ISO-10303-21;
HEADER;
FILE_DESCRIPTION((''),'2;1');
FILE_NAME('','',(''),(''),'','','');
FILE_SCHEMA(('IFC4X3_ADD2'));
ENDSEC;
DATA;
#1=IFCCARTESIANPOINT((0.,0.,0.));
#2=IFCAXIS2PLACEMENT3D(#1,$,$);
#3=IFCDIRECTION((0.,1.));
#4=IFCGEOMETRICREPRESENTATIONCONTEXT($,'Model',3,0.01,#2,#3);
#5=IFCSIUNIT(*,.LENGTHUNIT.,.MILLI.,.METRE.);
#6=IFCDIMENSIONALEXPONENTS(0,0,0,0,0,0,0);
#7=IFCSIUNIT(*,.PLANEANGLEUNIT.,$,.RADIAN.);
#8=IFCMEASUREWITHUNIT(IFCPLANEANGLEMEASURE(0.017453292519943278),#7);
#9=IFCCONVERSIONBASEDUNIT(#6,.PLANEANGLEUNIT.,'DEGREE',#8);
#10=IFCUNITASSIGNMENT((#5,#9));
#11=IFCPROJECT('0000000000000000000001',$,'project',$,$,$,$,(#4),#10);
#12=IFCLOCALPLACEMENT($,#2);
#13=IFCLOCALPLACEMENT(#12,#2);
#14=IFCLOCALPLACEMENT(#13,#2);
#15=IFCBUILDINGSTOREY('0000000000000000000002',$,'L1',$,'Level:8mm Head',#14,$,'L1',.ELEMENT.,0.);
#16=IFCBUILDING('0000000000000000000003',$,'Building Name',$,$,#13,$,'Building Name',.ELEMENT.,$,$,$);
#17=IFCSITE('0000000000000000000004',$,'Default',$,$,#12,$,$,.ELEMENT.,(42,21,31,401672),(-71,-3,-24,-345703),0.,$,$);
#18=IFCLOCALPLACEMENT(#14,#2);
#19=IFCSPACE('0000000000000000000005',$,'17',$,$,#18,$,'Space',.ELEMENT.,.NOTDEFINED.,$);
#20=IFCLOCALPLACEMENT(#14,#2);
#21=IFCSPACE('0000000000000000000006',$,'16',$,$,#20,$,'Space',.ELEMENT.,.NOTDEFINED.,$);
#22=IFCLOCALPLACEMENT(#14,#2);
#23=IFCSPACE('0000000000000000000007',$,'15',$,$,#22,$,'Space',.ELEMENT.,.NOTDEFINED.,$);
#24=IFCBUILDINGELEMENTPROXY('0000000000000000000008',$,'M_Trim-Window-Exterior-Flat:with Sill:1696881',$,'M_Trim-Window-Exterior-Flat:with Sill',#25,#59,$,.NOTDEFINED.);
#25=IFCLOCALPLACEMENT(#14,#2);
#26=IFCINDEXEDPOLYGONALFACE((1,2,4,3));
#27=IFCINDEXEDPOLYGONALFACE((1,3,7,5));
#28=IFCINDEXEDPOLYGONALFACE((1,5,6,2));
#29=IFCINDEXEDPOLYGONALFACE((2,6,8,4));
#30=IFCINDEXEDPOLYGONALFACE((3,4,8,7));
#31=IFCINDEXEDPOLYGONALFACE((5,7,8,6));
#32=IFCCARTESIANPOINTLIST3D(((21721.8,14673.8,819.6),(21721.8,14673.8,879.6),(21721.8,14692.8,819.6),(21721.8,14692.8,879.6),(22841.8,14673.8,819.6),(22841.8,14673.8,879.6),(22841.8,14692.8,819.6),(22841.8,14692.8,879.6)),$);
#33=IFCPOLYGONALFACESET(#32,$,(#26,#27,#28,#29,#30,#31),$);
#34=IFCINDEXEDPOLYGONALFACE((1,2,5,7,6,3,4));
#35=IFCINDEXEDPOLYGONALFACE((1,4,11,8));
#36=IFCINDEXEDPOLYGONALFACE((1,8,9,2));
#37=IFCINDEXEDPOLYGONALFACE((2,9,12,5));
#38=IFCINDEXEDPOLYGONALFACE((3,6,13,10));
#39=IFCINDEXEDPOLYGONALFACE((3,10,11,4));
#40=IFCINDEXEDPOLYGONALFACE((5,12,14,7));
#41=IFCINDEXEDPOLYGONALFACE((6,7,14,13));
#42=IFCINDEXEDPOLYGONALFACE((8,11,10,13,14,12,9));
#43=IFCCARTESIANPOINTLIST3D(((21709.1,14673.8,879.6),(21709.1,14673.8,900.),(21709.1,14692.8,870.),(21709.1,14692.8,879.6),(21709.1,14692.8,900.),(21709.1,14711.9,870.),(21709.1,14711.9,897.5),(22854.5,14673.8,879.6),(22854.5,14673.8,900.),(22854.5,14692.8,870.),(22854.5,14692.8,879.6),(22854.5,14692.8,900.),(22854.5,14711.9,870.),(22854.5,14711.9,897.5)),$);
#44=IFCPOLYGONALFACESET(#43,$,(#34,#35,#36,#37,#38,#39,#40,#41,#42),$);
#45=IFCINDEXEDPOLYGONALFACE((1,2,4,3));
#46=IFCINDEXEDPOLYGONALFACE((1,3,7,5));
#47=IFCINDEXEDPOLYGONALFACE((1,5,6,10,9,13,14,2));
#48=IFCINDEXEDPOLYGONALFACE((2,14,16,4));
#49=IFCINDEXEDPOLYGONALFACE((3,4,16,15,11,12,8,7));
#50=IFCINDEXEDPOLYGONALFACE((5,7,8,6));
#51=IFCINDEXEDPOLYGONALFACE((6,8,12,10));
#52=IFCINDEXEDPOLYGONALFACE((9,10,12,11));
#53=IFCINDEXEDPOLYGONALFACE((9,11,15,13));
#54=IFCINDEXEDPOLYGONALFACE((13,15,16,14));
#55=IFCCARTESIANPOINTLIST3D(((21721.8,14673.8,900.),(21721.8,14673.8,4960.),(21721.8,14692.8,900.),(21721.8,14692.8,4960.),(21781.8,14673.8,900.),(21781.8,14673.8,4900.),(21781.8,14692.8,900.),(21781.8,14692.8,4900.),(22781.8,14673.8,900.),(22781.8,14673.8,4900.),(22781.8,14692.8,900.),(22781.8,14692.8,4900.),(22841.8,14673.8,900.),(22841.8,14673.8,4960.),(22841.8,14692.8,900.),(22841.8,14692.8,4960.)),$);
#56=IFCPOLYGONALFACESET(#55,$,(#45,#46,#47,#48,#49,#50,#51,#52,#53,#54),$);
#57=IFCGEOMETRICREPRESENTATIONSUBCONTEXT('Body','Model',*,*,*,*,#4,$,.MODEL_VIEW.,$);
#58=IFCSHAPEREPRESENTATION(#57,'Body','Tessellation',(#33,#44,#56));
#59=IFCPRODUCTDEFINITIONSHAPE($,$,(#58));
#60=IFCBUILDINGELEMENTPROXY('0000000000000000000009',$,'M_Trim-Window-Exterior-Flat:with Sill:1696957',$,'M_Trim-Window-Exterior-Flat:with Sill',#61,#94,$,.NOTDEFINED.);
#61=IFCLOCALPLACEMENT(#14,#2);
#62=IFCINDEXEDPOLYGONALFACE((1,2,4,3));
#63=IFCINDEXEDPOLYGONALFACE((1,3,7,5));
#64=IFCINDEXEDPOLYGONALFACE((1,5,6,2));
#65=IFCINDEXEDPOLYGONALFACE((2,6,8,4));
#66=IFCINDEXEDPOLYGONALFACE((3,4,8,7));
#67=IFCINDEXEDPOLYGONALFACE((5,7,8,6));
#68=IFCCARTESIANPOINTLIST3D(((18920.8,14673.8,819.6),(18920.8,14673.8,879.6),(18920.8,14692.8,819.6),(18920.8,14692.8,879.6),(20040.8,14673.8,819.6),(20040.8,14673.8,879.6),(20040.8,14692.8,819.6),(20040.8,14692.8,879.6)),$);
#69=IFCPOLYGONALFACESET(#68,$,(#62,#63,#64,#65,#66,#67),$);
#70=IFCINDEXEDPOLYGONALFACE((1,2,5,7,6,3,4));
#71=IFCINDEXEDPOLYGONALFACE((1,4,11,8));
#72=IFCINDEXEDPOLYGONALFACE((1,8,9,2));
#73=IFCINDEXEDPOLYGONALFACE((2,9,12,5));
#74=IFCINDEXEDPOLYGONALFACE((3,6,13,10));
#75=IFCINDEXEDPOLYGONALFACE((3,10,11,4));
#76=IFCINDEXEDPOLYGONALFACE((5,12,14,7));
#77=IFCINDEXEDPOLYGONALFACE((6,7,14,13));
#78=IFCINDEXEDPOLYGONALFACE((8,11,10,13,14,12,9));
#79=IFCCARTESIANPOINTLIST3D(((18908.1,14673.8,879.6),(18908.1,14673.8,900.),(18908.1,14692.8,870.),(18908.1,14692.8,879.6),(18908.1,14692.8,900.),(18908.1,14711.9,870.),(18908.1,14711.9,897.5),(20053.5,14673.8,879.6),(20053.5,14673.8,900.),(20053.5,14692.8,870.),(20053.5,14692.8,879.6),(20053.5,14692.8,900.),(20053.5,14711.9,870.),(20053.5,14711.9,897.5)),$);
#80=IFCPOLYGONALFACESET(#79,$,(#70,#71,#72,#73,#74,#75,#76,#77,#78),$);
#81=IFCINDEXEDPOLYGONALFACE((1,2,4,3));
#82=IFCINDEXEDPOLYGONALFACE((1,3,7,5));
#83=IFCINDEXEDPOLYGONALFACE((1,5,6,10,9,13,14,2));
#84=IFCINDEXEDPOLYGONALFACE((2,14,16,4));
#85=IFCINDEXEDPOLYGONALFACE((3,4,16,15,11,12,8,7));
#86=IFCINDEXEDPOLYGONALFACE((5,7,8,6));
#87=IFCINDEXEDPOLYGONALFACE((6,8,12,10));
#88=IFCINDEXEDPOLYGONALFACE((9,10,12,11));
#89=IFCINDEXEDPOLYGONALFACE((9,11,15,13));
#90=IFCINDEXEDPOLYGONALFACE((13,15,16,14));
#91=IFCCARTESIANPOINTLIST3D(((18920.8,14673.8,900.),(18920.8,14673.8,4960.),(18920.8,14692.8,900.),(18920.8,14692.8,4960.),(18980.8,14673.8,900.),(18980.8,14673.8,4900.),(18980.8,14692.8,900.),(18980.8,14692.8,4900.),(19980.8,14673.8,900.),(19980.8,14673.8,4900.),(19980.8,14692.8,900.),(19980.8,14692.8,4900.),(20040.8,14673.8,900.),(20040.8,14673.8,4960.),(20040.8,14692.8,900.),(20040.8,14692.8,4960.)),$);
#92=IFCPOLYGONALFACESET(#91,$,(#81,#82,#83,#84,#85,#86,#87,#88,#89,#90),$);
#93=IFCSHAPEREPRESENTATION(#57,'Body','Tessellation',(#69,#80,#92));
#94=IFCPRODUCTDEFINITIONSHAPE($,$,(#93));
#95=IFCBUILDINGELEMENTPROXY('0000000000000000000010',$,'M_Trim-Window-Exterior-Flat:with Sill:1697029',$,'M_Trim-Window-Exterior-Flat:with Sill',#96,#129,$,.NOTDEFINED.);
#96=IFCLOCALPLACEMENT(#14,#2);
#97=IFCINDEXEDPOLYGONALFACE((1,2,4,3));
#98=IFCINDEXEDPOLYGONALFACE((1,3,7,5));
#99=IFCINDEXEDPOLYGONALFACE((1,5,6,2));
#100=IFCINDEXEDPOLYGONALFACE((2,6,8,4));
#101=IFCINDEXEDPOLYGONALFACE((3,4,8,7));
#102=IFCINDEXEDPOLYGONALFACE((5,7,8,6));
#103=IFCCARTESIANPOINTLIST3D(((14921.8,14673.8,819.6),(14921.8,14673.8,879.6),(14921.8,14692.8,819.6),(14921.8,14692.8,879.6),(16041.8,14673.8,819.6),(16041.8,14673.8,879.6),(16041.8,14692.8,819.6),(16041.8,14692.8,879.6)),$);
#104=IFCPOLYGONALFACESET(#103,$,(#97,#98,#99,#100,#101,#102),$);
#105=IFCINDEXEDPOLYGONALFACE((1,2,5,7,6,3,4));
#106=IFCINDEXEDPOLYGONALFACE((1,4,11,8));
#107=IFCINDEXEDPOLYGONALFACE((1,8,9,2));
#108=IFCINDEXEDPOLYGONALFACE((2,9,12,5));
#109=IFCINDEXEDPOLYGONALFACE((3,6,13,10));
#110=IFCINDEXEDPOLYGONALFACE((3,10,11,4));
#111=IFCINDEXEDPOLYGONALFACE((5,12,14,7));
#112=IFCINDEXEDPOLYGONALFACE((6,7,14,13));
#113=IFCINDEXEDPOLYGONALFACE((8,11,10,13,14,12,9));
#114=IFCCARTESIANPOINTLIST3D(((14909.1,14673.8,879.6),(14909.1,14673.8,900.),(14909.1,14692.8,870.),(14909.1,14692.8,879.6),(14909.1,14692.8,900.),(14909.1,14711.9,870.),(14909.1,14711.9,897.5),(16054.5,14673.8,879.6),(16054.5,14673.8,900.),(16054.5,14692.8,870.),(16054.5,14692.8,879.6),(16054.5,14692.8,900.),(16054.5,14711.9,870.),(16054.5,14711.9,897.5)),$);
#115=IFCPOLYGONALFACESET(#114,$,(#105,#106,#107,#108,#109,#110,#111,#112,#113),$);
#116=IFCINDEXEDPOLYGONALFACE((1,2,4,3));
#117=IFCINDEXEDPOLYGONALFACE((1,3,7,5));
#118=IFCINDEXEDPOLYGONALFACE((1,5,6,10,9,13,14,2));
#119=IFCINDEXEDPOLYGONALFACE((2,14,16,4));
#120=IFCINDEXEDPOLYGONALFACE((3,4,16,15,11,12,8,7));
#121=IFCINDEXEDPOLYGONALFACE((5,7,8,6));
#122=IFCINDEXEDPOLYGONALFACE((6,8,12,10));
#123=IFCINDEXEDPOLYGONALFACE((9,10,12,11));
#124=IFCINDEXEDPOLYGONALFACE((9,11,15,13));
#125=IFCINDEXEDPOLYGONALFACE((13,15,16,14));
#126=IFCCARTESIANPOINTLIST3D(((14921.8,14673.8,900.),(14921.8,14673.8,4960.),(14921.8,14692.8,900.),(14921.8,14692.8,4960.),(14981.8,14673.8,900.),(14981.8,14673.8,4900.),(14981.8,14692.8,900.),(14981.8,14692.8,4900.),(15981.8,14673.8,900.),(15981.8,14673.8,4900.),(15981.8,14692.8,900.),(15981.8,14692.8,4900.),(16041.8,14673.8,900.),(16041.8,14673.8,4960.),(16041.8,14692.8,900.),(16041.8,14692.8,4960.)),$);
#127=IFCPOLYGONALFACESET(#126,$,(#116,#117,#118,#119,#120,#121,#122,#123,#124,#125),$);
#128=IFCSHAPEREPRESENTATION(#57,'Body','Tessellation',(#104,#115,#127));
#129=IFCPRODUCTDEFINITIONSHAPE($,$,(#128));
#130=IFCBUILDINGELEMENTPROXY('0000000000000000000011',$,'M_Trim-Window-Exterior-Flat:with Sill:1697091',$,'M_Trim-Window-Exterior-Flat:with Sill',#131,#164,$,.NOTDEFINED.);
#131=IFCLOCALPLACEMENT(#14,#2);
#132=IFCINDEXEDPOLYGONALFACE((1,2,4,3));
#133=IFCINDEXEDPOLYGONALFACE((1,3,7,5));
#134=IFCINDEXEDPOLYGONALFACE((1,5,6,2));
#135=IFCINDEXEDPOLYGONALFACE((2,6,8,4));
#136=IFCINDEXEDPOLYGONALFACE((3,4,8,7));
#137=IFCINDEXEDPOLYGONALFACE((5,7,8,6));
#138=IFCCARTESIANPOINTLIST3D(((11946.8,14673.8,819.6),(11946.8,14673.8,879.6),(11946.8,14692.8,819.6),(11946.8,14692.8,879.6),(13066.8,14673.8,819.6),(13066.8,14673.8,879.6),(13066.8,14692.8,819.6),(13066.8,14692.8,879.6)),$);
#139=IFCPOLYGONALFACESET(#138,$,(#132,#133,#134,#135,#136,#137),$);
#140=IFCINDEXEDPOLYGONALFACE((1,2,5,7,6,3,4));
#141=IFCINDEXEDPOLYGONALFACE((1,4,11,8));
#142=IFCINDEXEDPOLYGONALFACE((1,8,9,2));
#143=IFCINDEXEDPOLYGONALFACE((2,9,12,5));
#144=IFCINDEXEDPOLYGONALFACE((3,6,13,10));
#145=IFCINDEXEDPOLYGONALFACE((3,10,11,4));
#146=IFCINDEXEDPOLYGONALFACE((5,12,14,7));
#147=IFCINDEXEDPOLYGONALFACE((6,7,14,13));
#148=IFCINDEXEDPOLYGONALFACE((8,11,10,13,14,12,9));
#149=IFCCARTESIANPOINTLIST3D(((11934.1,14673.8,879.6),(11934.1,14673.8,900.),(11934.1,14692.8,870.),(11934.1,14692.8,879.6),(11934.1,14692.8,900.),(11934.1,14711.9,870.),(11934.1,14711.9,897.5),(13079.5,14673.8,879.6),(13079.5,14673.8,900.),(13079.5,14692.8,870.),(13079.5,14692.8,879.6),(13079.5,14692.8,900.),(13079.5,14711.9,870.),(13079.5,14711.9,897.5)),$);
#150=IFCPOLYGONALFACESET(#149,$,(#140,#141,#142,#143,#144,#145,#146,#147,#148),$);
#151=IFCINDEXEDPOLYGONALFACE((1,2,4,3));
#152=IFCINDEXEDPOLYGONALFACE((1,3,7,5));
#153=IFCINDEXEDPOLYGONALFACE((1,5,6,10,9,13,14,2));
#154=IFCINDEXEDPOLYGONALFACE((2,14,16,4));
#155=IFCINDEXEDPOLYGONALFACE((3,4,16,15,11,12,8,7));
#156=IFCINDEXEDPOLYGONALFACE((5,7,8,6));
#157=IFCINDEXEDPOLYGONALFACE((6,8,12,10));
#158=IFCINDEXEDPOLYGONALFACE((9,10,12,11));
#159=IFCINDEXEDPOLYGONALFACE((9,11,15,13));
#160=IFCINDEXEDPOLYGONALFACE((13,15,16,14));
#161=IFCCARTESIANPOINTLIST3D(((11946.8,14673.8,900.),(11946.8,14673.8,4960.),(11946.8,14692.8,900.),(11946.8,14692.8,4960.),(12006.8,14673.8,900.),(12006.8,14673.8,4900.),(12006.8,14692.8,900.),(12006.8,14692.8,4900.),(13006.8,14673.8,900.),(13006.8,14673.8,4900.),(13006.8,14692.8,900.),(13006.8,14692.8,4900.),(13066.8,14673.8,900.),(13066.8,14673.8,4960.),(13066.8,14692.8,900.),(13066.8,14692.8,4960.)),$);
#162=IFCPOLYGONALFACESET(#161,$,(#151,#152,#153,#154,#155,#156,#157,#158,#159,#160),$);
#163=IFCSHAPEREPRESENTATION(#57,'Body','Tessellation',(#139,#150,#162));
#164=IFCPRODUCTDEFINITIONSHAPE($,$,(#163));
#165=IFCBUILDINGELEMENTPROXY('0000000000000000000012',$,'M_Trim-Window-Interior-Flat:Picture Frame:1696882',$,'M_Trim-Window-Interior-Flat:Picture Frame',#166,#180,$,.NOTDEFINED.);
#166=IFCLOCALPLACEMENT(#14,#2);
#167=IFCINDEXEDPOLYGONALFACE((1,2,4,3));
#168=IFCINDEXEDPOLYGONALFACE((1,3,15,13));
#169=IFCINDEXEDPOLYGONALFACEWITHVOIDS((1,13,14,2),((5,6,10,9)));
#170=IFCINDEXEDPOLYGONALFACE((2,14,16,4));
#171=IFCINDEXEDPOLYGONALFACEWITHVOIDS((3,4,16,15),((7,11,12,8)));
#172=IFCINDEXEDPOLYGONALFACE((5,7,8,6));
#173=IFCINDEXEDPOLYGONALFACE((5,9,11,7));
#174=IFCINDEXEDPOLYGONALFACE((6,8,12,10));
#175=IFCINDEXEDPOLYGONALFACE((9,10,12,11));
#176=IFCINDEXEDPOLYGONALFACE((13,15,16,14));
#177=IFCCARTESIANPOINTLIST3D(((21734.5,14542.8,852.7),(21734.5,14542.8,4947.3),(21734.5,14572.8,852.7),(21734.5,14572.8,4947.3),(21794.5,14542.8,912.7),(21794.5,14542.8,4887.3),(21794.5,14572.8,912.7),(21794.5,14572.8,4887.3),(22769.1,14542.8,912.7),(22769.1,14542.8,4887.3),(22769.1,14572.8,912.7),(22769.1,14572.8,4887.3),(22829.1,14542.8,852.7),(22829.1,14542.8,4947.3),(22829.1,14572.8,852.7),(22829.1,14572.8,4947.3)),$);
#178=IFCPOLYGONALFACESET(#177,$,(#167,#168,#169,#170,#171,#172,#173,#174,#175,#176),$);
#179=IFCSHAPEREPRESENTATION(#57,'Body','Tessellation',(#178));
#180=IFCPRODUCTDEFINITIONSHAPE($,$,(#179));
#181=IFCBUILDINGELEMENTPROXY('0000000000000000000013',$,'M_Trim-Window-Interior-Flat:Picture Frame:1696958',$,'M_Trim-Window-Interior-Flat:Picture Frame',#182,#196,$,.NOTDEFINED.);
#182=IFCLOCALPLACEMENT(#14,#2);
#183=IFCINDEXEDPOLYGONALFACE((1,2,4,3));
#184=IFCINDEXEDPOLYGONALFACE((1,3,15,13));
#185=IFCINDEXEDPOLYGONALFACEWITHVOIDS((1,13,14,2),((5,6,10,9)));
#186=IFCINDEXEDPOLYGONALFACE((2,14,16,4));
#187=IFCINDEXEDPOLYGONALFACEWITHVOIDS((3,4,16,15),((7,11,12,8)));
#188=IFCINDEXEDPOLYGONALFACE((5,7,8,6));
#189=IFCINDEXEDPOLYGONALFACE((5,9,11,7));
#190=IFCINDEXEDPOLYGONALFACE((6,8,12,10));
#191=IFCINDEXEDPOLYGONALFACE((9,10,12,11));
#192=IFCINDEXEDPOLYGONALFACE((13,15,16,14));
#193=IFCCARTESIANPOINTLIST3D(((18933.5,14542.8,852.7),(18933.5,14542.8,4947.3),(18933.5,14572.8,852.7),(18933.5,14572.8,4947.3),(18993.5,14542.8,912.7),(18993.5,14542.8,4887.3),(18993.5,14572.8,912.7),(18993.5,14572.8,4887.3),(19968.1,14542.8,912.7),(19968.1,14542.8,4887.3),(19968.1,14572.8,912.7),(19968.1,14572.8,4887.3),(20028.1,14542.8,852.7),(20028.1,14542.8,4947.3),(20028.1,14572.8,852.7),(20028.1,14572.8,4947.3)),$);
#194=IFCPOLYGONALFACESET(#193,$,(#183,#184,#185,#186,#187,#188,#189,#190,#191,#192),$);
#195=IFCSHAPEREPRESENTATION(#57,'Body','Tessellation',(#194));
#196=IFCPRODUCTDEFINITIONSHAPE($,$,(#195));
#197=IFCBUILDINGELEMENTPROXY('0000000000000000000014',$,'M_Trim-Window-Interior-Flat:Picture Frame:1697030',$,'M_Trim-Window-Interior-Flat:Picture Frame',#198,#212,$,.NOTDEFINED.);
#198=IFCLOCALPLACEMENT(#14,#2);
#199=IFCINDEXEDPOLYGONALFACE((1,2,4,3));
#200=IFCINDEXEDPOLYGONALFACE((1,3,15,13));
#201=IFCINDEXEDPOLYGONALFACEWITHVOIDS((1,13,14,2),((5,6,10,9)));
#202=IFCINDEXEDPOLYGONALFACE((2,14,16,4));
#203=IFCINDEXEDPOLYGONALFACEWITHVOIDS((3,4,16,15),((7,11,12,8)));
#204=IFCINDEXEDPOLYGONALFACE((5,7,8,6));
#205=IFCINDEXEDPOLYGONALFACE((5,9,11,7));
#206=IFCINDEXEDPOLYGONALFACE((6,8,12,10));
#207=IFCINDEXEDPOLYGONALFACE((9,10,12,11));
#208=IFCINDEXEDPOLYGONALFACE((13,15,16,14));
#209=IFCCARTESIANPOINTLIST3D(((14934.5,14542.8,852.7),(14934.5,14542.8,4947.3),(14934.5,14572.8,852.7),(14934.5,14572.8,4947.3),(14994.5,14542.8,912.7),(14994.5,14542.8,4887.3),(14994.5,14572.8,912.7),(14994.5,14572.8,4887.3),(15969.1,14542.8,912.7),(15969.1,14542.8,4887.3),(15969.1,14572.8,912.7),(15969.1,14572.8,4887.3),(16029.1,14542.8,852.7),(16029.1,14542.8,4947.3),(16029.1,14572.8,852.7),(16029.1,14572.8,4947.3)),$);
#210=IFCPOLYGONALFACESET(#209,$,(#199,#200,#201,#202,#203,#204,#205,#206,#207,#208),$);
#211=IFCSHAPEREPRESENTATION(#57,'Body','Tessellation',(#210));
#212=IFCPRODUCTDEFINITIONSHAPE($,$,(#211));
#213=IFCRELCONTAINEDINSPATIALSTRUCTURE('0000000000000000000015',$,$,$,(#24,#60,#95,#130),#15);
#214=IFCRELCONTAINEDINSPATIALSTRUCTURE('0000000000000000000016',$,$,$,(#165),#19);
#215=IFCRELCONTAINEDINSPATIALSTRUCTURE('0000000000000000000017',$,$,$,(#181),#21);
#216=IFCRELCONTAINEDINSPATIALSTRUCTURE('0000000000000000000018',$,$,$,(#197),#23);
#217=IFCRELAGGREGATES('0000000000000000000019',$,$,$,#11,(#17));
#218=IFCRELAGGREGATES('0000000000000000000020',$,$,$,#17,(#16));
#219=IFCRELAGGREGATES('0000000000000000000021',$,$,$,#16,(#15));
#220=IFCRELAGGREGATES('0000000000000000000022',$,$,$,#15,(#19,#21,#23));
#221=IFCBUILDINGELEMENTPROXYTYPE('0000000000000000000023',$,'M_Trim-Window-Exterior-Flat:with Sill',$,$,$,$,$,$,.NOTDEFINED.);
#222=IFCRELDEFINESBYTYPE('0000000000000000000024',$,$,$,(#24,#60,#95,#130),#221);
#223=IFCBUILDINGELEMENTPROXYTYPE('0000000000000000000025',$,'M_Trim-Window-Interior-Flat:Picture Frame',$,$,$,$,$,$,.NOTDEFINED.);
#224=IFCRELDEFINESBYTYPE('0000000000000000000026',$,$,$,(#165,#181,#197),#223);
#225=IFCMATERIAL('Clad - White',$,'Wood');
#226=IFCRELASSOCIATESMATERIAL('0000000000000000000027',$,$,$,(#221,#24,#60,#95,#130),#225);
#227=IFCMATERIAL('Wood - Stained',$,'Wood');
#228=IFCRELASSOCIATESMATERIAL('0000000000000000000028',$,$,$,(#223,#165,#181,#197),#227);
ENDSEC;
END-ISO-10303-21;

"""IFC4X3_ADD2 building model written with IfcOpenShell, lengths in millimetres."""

from ifc_helpers import new_model, entity, si_unit, converted_unit, direction, frame, frame_2d, origin, place, context, subcontext, project, spatial, polyline, rectangle, outline, extrude, source, transform, mapped, material, type_object, type_shapes, element, save


model = new_model("IFC4X3_ADD2")

# Units and contexts
model_context = context("Model", 3, precision=0.01, world=origin(), true_north=direction((0.0, 1.0)))
body_context = subcontext(model_context, "Body", "Model", "MODEL_VIEW")
ifc_project = project(units=[si_unit("LENGTHUNIT", "METRE", prefix="MILLI"), converted_unit("PLANEANGLEUNIT", "DEGREE", entity("IfcPlaneAngleMeasure", 0.017453292519943278), si_unit("PLANEANGLEUNIT", "RADIAN"), dimensions=[0, 0, 0, 0, 0, 0, 0])], contexts=[model_context])

# Site, building, storey
site_placement = place(None, origin())
site = spatial("IfcSite", under=ifc_project, at=site_placement, Name="Default", CompositionType="ELEMENT", RefLatitude=(42, 21, 31, 401672), RefLongitude=(-71, -3, -24, -345703), RefElevation=0.0)
building_placement = place(site_placement, origin())
building = spatial("IfcBuilding", under=site, at=building_placement, Name="Building Name", LongName="Building Name", CompositionType="ELEMENT")
storey_placement = place(building_placement, origin())
storey = spatial("IfcBuildingStorey", under=building, at=storey_placement, Name="L1", ObjectType="Level:8mm Head", LongName="L1", CompositionType="ELEMENT", Elevation=0.0)

# Building element proxies
ifc_material_1 = material(Name="Clad - White", Category="Wood")
ifc_material_2 = material(Name="Wood - Stained", Category="Wood")
building_element_proxy_type_1 = type_object("IfcBuildingElementProxyType", Name="M_Trim-Window-Exterior-Flat:with Sill", PredefinedType="NOTDEFINED", material=ifc_material_1)
shared_shape_1 = source(origin(), body_context, "Body", "SweptSolid", [
    extrude(rectangle(XDim=1120.0, YDim=60.0, at=frame_2d((0.0, 0.0), x_axis=(1.0, 0.0))), frame((0.0, -4050.4, 0.0), z_axis=(0.0, 0.0, 1.0), x_axis=(-1.0, 0.0, 0.0)), (0.0, 0.0, 1.0), 19.0),
    extrude(outline(polyline([(-19.0, -15.2), (0.0, -15.2), (0.0, -5.7), (19.0, -5.7), (19.0, 14.8), (0.0, 14.8), (-19.0, 12.3), (-19.0, -15.2)])), frame((-572.7, -4014.8, 19.0), z_axis=(1.0, 0.0, 0.0), x_axis=(0.0, 0.0, -1.0)), (0.0, 0.0, 1.0), 1145.4),
    extrude(outline(polyline([(-2045.0, -560.0), (2015.0, -560.0), (2015.0, -500.0), (-1985.0, -500.0), (-1985.0, 500.0), (2015.0, 500.0), (2015.0, 560.0), (-2045.0, 560.0), (-2045.0, -560.0)])), frame((0.0, -1985.0, 0.0), z_axis=(0.0, 0.0, 1.0), x_axis=(0.0, -1.0, 0.0)), (0.0, 0.0, 1.0), 19.0),
])
type_shapes(building_element_proxy_type_1, [shared_shape_1])
for number, where, z_axis, x_axis, name in (
    (1, (22281.8, 14673.8, 4900.0), (0.0, 1.0, 0.0), (-1.0, 0.0, 0.0), "M_Trim-Window-Exterior-Flat:with Sill:1696881"),
    (2, (19480.8, 14673.8, 4900.0), (0.0, 1.0, 0.0), (-1.0, 0.0, 0.0), "M_Trim-Window-Exterior-Flat:with Sill:1696957"),
    (3, (15481.8, 14673.8, 4900.0), (0.0, 1.0, 0.0), (-1.0, 0.0, 0.0), "M_Trim-Window-Exterior-Flat:with Sill:1697029"),
    (4, (12506.8, 14673.8, 4900.0), (0.0, 1.0, 0.0), (-1.0, 0.0, 0.0), "M_Trim-Window-Exterior-Flat:with Sill:1697091"),
):
    element("IfcBuildingElementProxy", number, at=place(storey_placement, frame(where, z_axis=z_axis, x_axis=x_axis)), inside=storey, type_object=building_element_proxy_type_1, material=ifc_material_1, Name=name, ObjectType="M_Trim-Window-Exterior-Flat:with Sill", PredefinedType="NOTDEFINED", context=body_context, shape_type="MappedRepresentation", body=[
        mapped(shared_shape_1, transform((0.0, 0.0, 0.0), scale=1.0)),
    ])

# Shared definitions
space_1_placement = place(storey_placement, origin())
space_1 = spatial("IfcSpace", under=storey, at=space_1_placement, Name="17", LongName="Space", CompositionType="ELEMENT", PredefinedType="NOTDEFINED")

# Building element proxy
building_element_proxy_type_2 = type_object("IfcBuildingElementProxyType", Name="M_Trim-Window-Interior-Flat:Picture Frame", PredefinedType="NOTDEFINED", material=ifc_material_2)
shared_shape_2 = source(origin(), body_context, "Body", "SweptSolid", [
    extrude(outline(polyline([(-547.3, -2047.3), (547.3, -2047.3), (547.3, 2047.3), (-547.3, 2047.3), (-547.3, -2047.3)]), holes=[polyline([(-487.3, -1987.3), (-487.3, 1987.3), (487.3, 1987.3), (487.3, -1987.3), (-487.3, -1987.3)])]), frame((0.0, -2000.0, 0.0), z_axis=(0.0, 0.0, 1.0), x_axis=(-1.0, 0.0, 0.0)), (0.0, 0.0, 1.0), 30.0),
])
type_shapes(building_element_proxy_type_2, [shared_shape_2])
proxy_1_placement = place(space_1_placement, frame((22281.8, 14572.8, 4900.0), z_axis=(0.0, -1.0, 0.0), x_axis=(1.0, 0.0, 0.0)))
element("IfcBuildingElementProxy", 5, at=proxy_1_placement, inside=space_1, type_object=building_element_proxy_type_2, material=ifc_material_2, Name="M_Trim-Window-Interior-Flat:Picture Frame:1696882", ObjectType="M_Trim-Window-Interior-Flat:Picture Frame", PredefinedType="NOTDEFINED", context=body_context, shape_type="MappedRepresentation", body=[
    mapped(shared_shape_2, transform((0.0, 0.0, 0.0), scale=1.0)),
])

# Shared definitions
space_2_placement = place(storey_placement, origin())
space_2 = spatial("IfcSpace", under=storey, at=space_2_placement, Name="16", LongName="Space", CompositionType="ELEMENT", PredefinedType="NOTDEFINED")

# Building element proxy
proxy_2_placement = place(space_2_placement, frame((19480.8, 14572.8, 4900.0), z_axis=(0.0, -1.0, 0.0), x_axis=(1.0, 0.0, 0.0)))
element("IfcBuildingElementProxy", 6, at=proxy_2_placement, inside=space_2, type_object=building_element_proxy_type_2, material=ifc_material_2, Name="M_Trim-Window-Interior-Flat:Picture Frame:1696958", ObjectType="M_Trim-Window-Interior-Flat:Picture Frame", PredefinedType="NOTDEFINED", context=body_context, shape_type="MappedRepresentation", body=[
    mapped(shared_shape_2, transform((0.0, 0.0, 0.0), scale=1.0)),
])

# Shared definitions
space_3_placement = place(storey_placement, origin())
space_3 = spatial("IfcSpace", under=storey, at=space_3_placement, Name="15", LongName="Space", CompositionType="ELEMENT", PredefinedType="NOTDEFINED")

# Building element proxy
proxy_3_placement = place(space_3_placement, frame((15481.8, 14572.8, 4900.0), z_axis=(0.0, -1.0, 0.0), x_axis=(1.0, 0.0, 0.0)))
element("IfcBuildingElementProxy", 7, at=proxy_3_placement, inside=space_3, type_object=building_element_proxy_type_2, material=ifc_material_2, Name="M_Trim-Window-Interior-Flat:Picture Frame:1697030", ObjectType="M_Trim-Window-Interior-Flat:Picture Frame", PredefinedType="NOTDEFINED", context=body_context, shape_type="MappedRepresentation", body=[
    mapped(shared_shape_2, transform((0.0, 0.0, 0.0), scale=1.0)),
])

save(model, "model.ifc")
